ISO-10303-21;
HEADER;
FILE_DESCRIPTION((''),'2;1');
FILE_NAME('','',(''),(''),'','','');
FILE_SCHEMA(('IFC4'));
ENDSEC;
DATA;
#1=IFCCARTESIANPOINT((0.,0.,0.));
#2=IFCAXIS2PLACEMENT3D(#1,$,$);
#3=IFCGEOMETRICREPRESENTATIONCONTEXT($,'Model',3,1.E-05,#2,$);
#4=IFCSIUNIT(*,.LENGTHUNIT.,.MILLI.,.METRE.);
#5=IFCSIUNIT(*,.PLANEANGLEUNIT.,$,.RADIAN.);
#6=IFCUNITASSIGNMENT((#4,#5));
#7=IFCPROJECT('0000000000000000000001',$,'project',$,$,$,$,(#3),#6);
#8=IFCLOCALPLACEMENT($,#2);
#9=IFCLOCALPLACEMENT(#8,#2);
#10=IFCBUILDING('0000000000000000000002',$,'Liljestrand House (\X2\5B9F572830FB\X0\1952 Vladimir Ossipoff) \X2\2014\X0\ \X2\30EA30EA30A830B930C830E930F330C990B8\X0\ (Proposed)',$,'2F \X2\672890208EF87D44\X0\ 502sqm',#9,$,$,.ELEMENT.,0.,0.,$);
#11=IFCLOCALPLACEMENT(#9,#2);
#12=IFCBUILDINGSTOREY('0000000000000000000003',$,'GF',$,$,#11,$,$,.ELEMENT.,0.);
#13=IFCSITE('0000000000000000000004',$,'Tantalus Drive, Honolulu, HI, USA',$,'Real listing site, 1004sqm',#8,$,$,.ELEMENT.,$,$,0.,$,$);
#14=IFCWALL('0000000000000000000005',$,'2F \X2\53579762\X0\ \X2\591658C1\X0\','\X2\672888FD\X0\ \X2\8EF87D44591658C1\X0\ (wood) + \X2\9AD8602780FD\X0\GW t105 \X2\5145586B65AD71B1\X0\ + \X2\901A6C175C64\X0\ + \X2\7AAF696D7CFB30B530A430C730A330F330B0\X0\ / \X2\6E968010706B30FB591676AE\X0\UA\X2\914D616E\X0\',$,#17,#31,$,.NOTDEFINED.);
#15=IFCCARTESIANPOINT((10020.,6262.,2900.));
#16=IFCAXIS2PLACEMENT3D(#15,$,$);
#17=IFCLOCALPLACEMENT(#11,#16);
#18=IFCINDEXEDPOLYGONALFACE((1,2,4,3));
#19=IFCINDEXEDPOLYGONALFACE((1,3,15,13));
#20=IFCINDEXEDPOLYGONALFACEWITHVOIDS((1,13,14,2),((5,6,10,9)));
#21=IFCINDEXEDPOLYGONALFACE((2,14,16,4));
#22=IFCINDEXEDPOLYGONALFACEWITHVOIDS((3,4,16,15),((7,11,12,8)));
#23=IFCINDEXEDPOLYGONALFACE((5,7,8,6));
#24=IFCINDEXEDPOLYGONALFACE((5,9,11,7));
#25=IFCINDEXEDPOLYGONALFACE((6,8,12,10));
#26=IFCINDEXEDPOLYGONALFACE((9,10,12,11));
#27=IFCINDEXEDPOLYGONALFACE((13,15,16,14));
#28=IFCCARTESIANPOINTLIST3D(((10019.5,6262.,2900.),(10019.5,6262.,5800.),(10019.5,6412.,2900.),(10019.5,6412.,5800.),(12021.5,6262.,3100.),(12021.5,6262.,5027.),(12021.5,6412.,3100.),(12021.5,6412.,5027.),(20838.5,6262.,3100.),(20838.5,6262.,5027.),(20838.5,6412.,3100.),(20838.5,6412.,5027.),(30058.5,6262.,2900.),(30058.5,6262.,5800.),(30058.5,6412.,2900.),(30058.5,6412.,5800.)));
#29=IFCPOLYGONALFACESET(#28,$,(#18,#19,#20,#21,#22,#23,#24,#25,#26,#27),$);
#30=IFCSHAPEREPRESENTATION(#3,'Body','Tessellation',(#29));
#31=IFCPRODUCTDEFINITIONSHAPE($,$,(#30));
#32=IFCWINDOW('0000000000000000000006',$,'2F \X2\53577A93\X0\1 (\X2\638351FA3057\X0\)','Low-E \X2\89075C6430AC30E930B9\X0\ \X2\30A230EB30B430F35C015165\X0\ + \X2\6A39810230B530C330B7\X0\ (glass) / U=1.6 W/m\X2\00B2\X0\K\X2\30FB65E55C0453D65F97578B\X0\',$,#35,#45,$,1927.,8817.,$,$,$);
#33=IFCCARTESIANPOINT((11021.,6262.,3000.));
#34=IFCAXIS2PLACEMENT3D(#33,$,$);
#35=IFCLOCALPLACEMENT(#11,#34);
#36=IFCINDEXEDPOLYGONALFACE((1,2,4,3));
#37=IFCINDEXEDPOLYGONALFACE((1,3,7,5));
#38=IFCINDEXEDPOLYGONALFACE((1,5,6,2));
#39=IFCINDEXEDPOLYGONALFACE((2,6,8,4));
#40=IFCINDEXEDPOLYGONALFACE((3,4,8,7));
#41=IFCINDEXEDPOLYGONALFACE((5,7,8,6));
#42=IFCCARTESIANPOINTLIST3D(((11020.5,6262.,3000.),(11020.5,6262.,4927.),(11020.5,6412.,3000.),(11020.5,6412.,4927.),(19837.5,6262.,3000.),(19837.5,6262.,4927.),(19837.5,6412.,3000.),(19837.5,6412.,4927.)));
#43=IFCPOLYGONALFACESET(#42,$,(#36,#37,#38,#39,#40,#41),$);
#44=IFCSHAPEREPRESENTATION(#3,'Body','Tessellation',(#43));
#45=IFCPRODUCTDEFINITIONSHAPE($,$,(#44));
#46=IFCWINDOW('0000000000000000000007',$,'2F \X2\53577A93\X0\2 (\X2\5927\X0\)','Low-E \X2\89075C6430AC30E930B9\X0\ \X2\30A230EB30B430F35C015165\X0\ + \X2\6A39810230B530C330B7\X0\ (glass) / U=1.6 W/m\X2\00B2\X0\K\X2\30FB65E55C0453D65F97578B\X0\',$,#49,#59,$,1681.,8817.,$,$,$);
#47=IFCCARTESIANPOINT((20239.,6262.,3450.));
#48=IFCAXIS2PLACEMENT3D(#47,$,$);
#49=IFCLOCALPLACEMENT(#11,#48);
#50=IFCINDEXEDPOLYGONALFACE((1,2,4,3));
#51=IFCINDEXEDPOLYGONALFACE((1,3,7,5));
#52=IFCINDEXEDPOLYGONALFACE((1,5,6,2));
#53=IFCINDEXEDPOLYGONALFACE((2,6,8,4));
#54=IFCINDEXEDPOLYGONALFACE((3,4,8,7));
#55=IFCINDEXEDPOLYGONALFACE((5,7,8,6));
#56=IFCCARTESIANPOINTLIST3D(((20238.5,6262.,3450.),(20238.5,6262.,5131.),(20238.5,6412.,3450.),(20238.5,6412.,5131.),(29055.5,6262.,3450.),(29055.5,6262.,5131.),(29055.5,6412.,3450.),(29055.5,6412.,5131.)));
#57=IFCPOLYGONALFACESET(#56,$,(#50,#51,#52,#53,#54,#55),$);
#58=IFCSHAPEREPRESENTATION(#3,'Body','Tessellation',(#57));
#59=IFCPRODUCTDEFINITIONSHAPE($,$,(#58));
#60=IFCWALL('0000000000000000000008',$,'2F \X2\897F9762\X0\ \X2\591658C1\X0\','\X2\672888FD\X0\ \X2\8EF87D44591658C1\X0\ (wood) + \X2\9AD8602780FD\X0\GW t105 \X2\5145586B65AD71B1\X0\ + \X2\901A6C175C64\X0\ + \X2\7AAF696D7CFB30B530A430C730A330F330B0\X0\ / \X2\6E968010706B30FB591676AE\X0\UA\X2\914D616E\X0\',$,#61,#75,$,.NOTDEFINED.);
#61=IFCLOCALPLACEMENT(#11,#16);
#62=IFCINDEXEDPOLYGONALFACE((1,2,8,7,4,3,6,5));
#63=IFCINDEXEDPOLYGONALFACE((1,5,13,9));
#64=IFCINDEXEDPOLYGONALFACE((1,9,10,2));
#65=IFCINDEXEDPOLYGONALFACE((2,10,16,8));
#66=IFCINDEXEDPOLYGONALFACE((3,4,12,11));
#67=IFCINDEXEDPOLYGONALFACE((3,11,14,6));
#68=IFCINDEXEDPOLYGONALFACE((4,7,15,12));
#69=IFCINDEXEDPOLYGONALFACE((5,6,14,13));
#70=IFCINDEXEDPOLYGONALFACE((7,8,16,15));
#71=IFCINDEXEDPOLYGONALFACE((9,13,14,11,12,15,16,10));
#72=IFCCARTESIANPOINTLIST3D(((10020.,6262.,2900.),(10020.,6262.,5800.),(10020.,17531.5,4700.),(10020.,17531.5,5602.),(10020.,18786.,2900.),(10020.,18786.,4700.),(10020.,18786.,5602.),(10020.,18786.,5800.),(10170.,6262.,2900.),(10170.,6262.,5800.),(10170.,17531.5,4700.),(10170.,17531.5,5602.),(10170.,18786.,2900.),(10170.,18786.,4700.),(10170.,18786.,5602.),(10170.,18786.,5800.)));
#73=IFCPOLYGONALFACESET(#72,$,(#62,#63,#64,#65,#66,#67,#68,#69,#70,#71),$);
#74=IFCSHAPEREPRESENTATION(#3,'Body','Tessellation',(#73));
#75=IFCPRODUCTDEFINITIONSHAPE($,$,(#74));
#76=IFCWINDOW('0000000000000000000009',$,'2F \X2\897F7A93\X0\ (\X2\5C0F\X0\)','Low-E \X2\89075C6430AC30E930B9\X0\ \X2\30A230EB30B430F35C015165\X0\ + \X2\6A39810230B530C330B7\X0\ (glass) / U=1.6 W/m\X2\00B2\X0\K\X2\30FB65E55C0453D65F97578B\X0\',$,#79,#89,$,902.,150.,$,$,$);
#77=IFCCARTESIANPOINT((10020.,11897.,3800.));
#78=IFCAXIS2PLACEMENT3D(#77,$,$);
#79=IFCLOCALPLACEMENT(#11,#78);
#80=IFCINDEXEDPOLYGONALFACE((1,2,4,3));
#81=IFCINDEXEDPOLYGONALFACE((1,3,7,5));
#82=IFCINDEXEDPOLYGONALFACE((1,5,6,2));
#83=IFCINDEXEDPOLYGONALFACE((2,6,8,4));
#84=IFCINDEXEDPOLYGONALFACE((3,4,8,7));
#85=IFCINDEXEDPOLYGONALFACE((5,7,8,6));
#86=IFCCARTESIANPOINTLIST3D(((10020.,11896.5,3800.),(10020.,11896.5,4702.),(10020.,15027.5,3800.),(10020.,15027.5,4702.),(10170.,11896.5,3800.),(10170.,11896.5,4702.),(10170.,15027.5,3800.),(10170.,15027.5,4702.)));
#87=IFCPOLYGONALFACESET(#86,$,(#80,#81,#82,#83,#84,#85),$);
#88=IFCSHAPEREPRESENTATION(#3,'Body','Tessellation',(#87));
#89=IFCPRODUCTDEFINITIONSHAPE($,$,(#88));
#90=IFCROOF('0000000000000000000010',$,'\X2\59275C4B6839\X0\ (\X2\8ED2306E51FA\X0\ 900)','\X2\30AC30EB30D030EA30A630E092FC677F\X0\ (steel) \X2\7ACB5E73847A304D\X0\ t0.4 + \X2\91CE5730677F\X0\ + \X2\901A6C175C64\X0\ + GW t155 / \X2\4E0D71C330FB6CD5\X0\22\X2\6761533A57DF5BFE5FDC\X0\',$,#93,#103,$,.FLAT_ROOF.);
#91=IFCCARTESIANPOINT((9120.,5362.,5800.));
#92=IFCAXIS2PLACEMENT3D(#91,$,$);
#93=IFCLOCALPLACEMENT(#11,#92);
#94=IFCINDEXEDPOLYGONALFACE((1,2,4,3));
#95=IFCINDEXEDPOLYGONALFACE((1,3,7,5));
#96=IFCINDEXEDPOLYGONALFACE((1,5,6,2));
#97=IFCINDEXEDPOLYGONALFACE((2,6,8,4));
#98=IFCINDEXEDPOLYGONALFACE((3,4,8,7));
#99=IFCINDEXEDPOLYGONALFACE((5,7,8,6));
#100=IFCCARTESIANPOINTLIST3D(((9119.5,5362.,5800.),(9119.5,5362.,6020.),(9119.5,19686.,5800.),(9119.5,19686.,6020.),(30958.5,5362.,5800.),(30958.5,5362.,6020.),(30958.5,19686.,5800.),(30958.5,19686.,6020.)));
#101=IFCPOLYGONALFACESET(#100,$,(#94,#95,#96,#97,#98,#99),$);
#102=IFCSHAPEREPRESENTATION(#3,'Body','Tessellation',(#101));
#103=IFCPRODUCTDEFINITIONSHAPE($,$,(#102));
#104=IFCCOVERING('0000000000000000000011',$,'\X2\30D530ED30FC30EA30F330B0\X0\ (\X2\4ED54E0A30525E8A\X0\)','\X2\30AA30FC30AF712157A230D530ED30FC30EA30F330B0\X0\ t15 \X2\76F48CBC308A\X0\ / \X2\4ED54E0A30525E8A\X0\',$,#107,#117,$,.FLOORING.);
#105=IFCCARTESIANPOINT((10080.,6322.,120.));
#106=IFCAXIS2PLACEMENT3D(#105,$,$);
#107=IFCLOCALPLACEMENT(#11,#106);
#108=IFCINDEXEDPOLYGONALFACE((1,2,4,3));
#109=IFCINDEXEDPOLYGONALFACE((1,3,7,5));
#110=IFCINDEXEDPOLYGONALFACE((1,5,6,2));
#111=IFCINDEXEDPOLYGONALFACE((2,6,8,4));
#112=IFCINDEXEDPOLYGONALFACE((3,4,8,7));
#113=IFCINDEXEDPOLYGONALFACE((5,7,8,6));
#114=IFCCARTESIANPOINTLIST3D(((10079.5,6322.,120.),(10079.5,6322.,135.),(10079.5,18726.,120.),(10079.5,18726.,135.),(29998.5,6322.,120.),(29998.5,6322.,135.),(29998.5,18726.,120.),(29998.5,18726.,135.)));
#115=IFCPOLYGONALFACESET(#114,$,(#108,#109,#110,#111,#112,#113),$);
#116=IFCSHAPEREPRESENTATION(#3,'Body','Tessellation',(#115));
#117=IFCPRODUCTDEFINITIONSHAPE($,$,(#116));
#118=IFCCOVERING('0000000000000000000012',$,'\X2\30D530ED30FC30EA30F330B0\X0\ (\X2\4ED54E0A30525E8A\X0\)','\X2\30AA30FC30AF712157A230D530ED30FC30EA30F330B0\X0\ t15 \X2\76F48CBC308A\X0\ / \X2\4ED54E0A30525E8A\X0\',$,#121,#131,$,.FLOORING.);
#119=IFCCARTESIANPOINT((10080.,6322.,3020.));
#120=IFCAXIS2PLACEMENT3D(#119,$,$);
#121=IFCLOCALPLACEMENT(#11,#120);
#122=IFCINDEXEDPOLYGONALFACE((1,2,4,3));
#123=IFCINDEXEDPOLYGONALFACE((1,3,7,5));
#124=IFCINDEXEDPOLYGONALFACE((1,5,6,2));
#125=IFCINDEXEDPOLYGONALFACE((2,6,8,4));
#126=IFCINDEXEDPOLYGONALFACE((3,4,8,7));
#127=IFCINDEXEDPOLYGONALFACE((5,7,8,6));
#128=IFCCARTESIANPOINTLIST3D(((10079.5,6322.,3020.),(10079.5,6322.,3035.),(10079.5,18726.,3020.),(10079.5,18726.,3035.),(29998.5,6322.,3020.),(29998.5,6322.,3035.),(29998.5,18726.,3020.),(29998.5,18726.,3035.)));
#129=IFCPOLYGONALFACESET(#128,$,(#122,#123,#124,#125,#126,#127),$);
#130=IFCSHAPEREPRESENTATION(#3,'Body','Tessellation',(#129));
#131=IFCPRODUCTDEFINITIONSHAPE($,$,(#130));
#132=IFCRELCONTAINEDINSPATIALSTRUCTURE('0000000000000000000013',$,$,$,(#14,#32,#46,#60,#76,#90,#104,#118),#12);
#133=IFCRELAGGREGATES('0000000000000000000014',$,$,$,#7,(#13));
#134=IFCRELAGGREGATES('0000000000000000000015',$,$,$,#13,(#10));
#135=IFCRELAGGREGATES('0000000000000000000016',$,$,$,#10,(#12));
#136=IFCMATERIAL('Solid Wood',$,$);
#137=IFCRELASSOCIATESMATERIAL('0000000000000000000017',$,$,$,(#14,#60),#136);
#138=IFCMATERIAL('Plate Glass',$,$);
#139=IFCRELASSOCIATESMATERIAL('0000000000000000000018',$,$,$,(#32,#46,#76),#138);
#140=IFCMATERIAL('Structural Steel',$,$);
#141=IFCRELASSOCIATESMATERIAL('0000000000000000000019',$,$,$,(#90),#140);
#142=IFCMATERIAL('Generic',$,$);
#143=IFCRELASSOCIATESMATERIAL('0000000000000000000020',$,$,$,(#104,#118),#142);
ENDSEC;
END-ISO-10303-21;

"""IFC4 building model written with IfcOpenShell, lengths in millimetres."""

from ifc_helpers import new_model, si_unit, frame, frame_2d, origin, place, context, project, spatial, rectangle, extrude, material, element, fill, save


model = new_model("IFC4")

# Units and contexts
model_context = context("Model", 3, precision=1e-05, world=origin())
ifc_project = project(units=[si_unit("LENGTHUNIT", "METRE", prefix="MILLI"), si_unit("PLANEANGLEUNIT", "RADIAN")], contexts=[model_context])

# Site, building, storey
site_placement = place(None, origin())
site = spatial("IfcSite", under=ifc_project, at=site_placement, Name="Tantalus Drive, Honolulu, HI, USA", ObjectType="Real listing site, 1004sqm", CompositionType="ELEMENT", RefElevation=0.0)
building_placement = place(site_placement, origin())
building = spatial("IfcBuilding", under=site, at=building_placement, Name="Liljestrand House (実在・1952 Vladimir Ossipoff) — リリエストランド邸 (Proposed)", ObjectType="2F 木造軸組 502sqm", CompositionType="ELEMENT", ElevationOfRefHeight=0.0, ElevationOfTerrain=0.0)
storey_placement = place(building_placement, origin())
storey = spatial("IfcBuildingStorey", under=building, at=storey_placement, Name="GF", CompositionType="ELEMENT", Elevation=0.0)

# Shared definitions
ifc_material_1 = material(Name="Solid Wood")

# Shared definitions
ifc_material_2 = material(Name="Plate Glass")

# Wall, openings, windows
wall_1_placement = place(storey_placement, frame((10020.0, 6262.0, 2900.0)))
wall_1 = element("IfcWall", 1, at=wall_1_placement, inside=storey, material=ifc_material_1, Name="2F 南面 外壁", Description="木製 軸組外壁 (wood) + 高性能GW t105 充填断熱 + 通気層 + 窯業系サイディング / 準耐火・外皮UA配慮", PredefinedType="NOTDEFINED", context=model_context, shape_type="SweptSolid", body=[
    extrude(rectangle(XDim=20039.0, YDim=150.0, at=frame_2d((10019.0, 75.0))), frame((10020.0, 6262.0, 2900.0)), (0.0, 0.0, 1.0), 2900.0),
])
opening_1_placement = place(storey_placement, frame((11021.0, 6262.0, 3000.0)))
opening_1 = element("IfcOpeningElement", 2, at=opening_1_placement, cuts=wall_1, PredefinedType="NOTDEFINED", context=model_context, shape_type="SweptSolid", body=[
    extrude(rectangle(XDim=8817.0, YDim=150.0, at=frame_2d((4408.0, 75.0))), frame((11021.0, 6262.0, 3000.0)), (0.0, 0.0, 1.0), 1927.0),
])
opening_2_placement = place(storey_placement, frame((20239.0, 6262.0, 3450.0)))
opening_2 = element("IfcOpeningElement", 3, at=opening_2_placement, cuts=wall_1, PredefinedType="NOTDEFINED", context=model_context, shape_type="SweptSolid", body=[
    extrude(rectangle(XDim=8817.0, YDim=150.0, at=frame_2d((4408.0, 75.0))), frame((20239.0, 6262.0, 3450.0)), (0.0, 0.0, 1.0), 1681.0),
])
window_1_placement = place(storey_placement, frame((11021.0, 6262.0, 3000.0)))
window_1 = element("IfcWindow", 4, at=window_1_placement, inside=storey, material=ifc_material_2, Name="2F 南窓1 (掃出し)", Description="Low-E 複層ガラス アルゴン封入 + 樹脂サッシ (glass) / U=1.6 W/m²K・日射取得型", OverallHeight=1927.0, OverallWidth=8817.0, context=model_context, shape_type="SweptSolid", body=[
    extrude(rectangle(XDim=8817.0, YDim=150.0, at=frame_2d((4408.0, 75.0))), frame((11021.0, 6262.0, 3000.0)), (0.0, 0.0, 1.0), 1927.0),
])
fill(opening_1, window_1)
window_2_placement = place(storey_placement, frame((20239.0, 6262.0, 3450.0)))
window_2 = element("IfcWindow", 5, at=window_2_placement, inside=storey, material=ifc_material_2, Name="2F 南窓2 (大)", Description="Low-E 複層ガラス アルゴン封入 + 樹脂サッシ (glass) / U=1.6 W/m²K・日射取得型", OverallHeight=1681.0, OverallWidth=8817.0, context=model_context, shape_type="SweptSolid", body=[
    extrude(rectangle(XDim=8817.0, YDim=150.0, at=frame_2d((4408.0, 75.0))), frame((20239.0, 6262.0, 3450.0)), (0.0, 0.0, 1.0), 1681.0),
])
fill(opening_2, window_2)

# Wall, opening, window
wall_2_placement = place(storey_placement, frame((10020.0, 6262.0, 2900.0)))
wall_2 = element("IfcWall", 6, at=wall_2_placement, inside=storey, material=ifc_material_1, Name="2F 西面 外壁", Description="木製 軸組外壁 (wood) + 高性能GW t105 充填断熱 + 通気層 + 窯業系サイディング / 準耐火・外皮UA配慮", PredefinedType="NOTDEFINED", context=model_context, shape_type="SweptSolid", body=[
    extrude(rectangle(XDim=150.0, YDim=12524.0, at=frame_2d((75.0, 6262.0))), frame((10020.0, 6262.0, 2900.0)), (0.0, 0.0, 1.0), 2900.0),
])
opening_3_placement = place(storey_placement, frame((10020.0, 11897.0, 3800.0)))
opening_3 = element("IfcOpeningElement", 7, at=opening_3_placement, cuts=wall_2, PredefinedType="NOTDEFINED", context=model_context, shape_type="SweptSolid", body=[
    extrude(rectangle(XDim=150.0, YDim=3131.0, at=frame_2d((75.0, 1565.0))), frame((10020.0, 11897.0, 3800.0)), (0.0, 0.0, 1.0), 902.0),
])
window_3_placement = place(storey_placement, frame((10020.0, 11897.0, 3800.0)))
window_3 = element("IfcWindow", 8, at=window_3_placement, inside=storey, material=ifc_material_2, Name="2F 西窓 (小)", Description="Low-E 複層ガラス アルゴン封入 + 樹脂サッシ (glass) / U=1.6 W/m²K・日射取得型", OverallHeight=902.0, OverallWidth=150.0, context=model_context, shape_type="SweptSolid", body=[
    extrude(rectangle(XDim=150.0, YDim=3131.0, at=frame_2d((75.0, 1565.0))), frame((10020.0, 11897.0, 3800.0)), (0.0, 0.0, 1.0), 902.0),
])
fill(opening_3, window_3)

# Roof
ifc_material_3 = material(Name="Structural Steel")
roof_placement = place(storey_placement, frame((9120.0, 5362.0, 5800.0)))
element("IfcRoof", 9, at=roof_placement, inside=storey, material=ifc_material_3, Name="大屋根 (軒の出 900)", Description="ガルバリウム鋼板 (steel) 立平葺き t0.4 + 野地板 + 通気層 + GW t155 / 不燃・法22条区域対応", PredefinedType="FLAT_ROOF", context=model_context, shape_type="SweptSolid", body=[
    extrude(rectangle(XDim=21839.0, YDim=14324.0, at=frame_2d((10919.0, 7162.0))), frame((9120.0, 5362.0, 5800.0)), (0.0, 0.0, 1.0), 220.0),
])

# Coverings
ifc_material_4 = material(Name="Generic")
covering_1_placement = place(storey_placement, frame((10080.0, 6322.0, 120.0)))
element("IfcCovering", 10, at=covering_1_placement, inside=storey, material=ifc_material_4, Name="フローリング (仕上げ床)", Description="オーク無垢フローリング t15 直貼り / 仕上げ床", PredefinedType="FLOORING", context=model_context, shape_type="SweptSolid", body=[
    extrude(rectangle(XDim=19919.0, YDim=12404.0, at=frame_2d((9959.0, 6202.0))), frame((10080.0, 6322.0, 120.0)), (0.0, 0.0, 1.0), 15.0),
])
covering_2_placement = place(storey_placement, frame((10080.0, 6322.0, 3020.0)))
element("IfcCovering", 11, at=covering_2_placement, inside=storey, material=ifc_material_4, Name="フローリング (仕上げ床)", Description="オーク無垢フローリング t15 直貼り / 仕上げ床", PredefinedType="FLOORING", context=model_context, shape_type="SweptSolid", body=[
    extrude(rectangle(XDim=19919.0, YDim=12404.0, at=frame_2d((9959.0, 6202.0))), frame((10080.0, 6322.0, 3020.0)), (0.0, 0.0, 1.0), 15.0),
])

save(model, "model.ifc")
